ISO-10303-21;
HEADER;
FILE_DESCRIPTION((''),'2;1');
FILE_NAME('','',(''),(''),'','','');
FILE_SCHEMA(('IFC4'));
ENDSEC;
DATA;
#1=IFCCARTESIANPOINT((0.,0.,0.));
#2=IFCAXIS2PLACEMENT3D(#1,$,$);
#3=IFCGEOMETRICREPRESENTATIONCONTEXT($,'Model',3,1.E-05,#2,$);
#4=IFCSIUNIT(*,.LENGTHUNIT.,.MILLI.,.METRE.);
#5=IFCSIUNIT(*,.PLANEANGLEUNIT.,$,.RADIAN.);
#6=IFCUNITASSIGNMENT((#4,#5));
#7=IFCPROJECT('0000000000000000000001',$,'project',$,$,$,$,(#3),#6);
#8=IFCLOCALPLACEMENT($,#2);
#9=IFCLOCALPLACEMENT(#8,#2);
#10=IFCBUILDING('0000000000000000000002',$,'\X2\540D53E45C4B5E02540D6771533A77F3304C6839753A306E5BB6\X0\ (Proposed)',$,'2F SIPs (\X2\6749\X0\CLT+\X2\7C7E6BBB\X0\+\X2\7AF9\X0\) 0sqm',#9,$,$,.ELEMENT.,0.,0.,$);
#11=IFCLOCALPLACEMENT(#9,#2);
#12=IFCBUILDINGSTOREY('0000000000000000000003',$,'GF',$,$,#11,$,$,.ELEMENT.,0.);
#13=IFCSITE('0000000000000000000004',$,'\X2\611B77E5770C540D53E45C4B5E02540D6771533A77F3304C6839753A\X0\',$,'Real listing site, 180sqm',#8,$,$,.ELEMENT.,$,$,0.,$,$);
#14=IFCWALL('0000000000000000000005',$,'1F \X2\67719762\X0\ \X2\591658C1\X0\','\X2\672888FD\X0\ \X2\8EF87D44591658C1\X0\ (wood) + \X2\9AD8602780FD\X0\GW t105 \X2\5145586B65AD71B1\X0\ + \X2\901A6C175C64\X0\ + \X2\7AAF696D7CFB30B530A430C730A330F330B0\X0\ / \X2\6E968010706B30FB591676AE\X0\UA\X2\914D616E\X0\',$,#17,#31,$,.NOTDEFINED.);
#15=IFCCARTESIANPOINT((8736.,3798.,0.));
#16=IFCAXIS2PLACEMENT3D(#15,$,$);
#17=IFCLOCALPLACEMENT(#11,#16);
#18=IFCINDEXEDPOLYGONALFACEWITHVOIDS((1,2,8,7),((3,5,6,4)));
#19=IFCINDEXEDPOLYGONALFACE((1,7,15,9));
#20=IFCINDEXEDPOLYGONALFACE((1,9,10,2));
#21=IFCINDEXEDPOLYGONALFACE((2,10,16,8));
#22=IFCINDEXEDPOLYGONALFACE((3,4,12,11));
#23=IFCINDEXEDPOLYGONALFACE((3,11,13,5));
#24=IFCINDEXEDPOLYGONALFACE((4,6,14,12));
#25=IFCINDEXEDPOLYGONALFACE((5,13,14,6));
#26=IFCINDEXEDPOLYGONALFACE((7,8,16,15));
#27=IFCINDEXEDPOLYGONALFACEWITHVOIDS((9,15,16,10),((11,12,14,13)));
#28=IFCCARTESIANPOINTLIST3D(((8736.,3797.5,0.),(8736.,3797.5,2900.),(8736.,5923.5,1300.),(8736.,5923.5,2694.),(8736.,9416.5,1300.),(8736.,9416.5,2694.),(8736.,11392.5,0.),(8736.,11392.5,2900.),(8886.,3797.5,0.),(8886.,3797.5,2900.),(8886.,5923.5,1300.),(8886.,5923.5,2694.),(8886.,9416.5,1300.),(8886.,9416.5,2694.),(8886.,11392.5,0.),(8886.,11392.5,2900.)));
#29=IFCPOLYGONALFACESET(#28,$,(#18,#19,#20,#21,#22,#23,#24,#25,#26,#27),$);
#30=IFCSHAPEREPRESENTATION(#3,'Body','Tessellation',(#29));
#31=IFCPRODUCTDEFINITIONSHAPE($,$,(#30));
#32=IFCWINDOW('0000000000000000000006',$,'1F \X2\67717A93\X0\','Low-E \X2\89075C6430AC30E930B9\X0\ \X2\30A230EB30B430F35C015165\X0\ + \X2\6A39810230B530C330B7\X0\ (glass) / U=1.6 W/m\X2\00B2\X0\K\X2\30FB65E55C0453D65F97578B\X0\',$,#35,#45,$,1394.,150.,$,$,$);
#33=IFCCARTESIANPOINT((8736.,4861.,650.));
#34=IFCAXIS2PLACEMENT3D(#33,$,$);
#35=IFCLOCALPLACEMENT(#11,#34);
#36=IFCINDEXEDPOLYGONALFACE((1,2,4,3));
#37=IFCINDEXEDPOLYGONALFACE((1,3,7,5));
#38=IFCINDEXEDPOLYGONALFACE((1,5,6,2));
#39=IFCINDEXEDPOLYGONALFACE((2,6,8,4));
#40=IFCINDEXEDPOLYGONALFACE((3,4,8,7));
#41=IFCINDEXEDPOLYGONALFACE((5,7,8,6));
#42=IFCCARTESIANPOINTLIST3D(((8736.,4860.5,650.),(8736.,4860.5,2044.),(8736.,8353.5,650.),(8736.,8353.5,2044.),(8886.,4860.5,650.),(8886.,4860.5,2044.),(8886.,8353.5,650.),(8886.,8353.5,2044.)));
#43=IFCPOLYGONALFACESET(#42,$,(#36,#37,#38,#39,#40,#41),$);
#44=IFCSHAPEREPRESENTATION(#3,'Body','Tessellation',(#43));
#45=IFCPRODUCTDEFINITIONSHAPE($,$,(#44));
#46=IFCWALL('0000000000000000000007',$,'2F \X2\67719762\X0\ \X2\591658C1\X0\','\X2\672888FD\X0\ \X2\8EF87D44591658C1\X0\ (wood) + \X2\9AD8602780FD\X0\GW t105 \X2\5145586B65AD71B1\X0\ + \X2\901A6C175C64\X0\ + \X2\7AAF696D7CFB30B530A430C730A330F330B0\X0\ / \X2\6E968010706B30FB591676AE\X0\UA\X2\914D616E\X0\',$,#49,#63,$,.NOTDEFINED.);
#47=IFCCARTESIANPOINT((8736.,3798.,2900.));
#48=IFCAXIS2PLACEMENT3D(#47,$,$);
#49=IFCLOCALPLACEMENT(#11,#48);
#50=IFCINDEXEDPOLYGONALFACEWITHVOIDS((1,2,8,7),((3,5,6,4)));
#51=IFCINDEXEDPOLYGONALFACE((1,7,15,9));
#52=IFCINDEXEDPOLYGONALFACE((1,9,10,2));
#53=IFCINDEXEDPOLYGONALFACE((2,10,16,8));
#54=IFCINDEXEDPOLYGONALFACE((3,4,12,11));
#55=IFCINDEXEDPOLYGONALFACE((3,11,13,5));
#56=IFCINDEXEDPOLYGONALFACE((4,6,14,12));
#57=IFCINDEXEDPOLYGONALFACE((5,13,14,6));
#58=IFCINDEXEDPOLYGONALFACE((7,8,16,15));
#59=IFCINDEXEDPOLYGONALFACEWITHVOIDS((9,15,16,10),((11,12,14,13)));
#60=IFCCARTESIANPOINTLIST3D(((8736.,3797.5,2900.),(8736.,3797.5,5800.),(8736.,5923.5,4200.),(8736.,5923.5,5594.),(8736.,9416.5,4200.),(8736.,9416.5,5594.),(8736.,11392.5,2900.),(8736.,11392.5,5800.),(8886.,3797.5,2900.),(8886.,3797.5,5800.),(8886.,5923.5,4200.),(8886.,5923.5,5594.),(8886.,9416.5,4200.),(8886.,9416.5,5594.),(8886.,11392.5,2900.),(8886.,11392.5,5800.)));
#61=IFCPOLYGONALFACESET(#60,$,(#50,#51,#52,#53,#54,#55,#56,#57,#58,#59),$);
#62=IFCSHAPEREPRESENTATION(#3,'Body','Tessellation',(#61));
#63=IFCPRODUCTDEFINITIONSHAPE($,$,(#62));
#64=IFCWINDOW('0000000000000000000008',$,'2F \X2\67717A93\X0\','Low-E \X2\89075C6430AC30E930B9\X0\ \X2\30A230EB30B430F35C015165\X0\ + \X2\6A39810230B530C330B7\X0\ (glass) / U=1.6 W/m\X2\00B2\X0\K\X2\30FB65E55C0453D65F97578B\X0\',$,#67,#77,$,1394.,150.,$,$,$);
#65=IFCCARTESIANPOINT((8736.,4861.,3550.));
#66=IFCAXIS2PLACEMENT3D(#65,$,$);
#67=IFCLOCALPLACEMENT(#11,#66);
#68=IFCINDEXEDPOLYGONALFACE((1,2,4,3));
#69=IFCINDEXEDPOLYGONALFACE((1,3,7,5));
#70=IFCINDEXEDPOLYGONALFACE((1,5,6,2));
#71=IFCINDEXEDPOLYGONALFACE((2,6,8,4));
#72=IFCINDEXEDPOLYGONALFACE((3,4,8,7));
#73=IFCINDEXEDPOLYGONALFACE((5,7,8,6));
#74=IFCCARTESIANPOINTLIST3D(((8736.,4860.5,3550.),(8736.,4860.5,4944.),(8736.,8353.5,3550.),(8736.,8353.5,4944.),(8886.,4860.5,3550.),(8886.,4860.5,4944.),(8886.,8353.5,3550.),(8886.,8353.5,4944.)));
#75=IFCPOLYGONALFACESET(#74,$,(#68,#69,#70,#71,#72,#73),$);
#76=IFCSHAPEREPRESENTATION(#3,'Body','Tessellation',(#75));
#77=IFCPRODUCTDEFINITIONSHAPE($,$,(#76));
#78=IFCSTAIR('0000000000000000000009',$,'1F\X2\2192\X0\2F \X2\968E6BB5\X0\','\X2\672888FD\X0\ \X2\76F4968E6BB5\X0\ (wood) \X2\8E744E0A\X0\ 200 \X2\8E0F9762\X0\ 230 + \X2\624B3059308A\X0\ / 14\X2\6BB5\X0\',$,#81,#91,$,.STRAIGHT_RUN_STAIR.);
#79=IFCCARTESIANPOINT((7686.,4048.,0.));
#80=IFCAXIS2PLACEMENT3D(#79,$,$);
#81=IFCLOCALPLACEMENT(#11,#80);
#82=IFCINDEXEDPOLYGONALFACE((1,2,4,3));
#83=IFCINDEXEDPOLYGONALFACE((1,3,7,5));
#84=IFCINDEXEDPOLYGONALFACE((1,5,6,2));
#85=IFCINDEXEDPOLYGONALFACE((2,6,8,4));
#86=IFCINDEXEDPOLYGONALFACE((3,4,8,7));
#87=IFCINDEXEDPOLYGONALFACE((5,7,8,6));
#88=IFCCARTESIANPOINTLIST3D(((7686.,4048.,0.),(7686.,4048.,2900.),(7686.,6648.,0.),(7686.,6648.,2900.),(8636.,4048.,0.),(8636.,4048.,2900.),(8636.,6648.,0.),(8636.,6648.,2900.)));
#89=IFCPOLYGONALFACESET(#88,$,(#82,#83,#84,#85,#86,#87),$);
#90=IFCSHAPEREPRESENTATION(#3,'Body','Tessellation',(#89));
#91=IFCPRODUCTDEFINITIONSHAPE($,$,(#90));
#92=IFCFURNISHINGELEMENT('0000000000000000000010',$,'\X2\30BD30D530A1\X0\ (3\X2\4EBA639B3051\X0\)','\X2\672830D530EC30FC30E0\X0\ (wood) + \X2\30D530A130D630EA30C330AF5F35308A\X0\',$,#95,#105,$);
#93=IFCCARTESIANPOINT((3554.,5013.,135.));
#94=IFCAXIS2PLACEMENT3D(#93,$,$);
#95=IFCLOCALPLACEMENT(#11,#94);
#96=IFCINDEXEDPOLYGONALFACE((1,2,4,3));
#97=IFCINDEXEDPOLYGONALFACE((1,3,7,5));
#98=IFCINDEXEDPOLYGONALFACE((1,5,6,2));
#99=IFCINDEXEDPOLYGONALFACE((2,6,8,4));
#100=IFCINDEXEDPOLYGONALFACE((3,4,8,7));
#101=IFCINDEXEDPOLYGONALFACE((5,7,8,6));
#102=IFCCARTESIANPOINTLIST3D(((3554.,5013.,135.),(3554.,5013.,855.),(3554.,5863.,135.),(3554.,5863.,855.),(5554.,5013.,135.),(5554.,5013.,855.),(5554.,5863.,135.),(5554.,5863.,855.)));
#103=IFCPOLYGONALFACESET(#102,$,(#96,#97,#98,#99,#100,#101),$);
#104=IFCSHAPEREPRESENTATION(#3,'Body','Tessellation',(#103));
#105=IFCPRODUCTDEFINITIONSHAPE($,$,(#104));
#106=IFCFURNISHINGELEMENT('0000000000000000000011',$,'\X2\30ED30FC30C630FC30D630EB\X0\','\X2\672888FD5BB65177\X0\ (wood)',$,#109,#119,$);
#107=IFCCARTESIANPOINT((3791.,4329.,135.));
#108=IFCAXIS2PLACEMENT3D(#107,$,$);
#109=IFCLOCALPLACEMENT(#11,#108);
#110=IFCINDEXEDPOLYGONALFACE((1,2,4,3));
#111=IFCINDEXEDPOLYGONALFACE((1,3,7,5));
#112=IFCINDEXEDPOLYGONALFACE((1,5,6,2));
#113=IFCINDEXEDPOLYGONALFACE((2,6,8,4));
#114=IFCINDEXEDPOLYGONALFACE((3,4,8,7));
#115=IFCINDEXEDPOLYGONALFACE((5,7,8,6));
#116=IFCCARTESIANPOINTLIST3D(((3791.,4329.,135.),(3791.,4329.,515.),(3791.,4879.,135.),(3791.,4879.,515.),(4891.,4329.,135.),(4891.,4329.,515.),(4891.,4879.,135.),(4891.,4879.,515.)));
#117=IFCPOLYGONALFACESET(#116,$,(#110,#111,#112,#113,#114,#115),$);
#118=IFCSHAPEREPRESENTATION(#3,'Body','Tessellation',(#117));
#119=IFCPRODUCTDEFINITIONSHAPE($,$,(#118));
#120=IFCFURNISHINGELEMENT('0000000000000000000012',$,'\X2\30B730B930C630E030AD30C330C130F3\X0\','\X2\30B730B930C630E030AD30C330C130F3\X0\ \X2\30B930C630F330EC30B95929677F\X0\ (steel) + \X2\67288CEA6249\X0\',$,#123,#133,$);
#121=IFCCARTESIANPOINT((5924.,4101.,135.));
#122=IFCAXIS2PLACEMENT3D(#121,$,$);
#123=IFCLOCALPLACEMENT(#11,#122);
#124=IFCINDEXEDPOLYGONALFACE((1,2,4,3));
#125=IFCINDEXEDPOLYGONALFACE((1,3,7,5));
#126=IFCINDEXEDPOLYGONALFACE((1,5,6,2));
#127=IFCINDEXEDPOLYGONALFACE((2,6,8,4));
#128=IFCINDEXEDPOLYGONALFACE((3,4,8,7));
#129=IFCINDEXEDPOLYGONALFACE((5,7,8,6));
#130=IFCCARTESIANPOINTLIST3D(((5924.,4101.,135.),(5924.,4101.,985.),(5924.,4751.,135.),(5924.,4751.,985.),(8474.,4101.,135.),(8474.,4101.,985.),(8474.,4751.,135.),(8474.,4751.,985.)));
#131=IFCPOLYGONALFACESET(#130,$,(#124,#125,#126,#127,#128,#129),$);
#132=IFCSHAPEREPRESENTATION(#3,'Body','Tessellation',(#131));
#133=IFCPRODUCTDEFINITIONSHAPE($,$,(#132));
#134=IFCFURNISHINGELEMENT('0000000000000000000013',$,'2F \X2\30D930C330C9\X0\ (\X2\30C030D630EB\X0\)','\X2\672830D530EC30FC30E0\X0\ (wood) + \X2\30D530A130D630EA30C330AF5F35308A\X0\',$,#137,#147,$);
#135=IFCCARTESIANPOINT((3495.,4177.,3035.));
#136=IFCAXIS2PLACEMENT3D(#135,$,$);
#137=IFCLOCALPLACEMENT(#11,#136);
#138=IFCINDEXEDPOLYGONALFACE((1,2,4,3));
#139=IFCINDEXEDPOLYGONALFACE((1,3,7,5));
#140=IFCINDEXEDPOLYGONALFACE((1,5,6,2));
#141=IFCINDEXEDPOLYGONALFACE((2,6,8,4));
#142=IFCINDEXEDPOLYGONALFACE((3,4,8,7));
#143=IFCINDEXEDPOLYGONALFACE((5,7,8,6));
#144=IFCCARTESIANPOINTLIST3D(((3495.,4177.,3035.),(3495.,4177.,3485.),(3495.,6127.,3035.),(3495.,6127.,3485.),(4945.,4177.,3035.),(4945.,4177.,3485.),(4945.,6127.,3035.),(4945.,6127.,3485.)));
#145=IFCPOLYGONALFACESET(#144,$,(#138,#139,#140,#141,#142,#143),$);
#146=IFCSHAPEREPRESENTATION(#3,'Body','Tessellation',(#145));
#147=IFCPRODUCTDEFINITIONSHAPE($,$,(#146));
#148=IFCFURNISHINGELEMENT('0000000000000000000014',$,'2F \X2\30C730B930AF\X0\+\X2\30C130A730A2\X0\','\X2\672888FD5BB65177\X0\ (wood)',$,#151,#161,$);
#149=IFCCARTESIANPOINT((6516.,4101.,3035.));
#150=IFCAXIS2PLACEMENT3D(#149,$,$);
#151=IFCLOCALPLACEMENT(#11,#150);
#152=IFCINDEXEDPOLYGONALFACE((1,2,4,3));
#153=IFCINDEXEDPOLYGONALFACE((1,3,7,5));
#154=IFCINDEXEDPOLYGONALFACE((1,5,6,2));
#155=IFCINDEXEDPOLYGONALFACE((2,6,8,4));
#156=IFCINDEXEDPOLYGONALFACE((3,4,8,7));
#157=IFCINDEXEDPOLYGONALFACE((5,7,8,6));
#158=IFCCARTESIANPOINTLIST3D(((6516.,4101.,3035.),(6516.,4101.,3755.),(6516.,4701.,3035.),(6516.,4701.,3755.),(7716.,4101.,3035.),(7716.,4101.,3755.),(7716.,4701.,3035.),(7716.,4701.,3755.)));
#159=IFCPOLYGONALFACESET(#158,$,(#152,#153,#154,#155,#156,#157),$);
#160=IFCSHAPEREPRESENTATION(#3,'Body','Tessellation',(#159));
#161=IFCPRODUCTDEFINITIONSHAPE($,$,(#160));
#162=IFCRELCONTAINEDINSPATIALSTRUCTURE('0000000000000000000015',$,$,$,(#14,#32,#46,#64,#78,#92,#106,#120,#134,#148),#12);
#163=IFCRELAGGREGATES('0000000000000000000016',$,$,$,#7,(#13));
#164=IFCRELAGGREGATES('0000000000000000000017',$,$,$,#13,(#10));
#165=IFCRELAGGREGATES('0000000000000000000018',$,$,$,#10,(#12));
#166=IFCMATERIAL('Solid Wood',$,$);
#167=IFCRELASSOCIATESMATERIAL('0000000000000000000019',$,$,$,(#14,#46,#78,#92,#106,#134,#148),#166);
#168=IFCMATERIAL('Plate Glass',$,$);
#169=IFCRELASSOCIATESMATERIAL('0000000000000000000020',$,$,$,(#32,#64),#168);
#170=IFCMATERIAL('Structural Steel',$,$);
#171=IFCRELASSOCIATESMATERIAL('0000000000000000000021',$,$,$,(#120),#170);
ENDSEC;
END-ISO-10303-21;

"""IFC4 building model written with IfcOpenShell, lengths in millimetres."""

from ifc_helpers import new_model, si_unit, frame, frame_2d, origin, place, context, project, spatial, rectangle, extrude, material, element, fill, save


model = new_model("IFC4")

# Units and contexts
model_context = context("Model", 3, precision=1e-05, world=origin())
ifc_project = project(units=[si_unit("LENGTHUNIT", "METRE", prefix="MILLI"), si_unit("PLANEANGLEUNIT", "RADIAN")], contexts=[model_context])

# Site, building, storey
site_placement = place(None, origin())
site = spatial("IfcSite", under=ifc_project, at=site_placement, Name="愛知県名古屋市名東区石が根町", ObjectType="Real listing site, 180sqm", CompositionType="ELEMENT", RefElevation=0.0)
building_placement = place(site_placement, origin())
building = spatial("IfcBuilding", under=site, at=building_placement, Name="名古屋市名東区石が根町の家 (Proposed)", ObjectType="2F SIPs (杉CLT+籾殻+竹) 0sqm", CompositionType="ELEMENT", ElevationOfRefHeight=0.0, ElevationOfTerrain=0.0)
storey_placement = place(building_placement, origin())
storey = spatial("IfcBuildingStorey", under=building, at=storey_placement, Name="GF", CompositionType="ELEMENT", Elevation=0.0)

# Wall, opening, window
ifc_material_1 = material(Name="Solid Wood")
wall_1_placement = place(storey_placement, frame((8736.0, 3798.0, 0.0)))
wall_1 = element("IfcWall", 1, at=wall_1_placement, inside=storey, material=ifc_material_1, Name="1F 東面 外壁", Description="木製 軸組外壁 (wood) + 高性能GW t105 充填断熱 + 通気層 + 窯業系サイディング / 準耐火・外皮UA配慮", PredefinedType="NOTDEFINED", context=model_context, shape_type="SweptSolid", body=[
    extrude(rectangle(XDim=150.0, YDim=7595.0, at=frame_2d((75.0, 3797.0))), frame((8736.0, 3798.0, 0.0)), (0.0, 0.0, 1.0), 2900.0),
])
opening_1_placement = place(storey_placement, frame((8736.0, 4861.0, 650.0)))
opening_1 = element("IfcOpeningElement", 2, at=opening_1_placement, cuts=wall_1, PredefinedType="NOTDEFINED", context=model_context, shape_type="SweptSolid", body=[
    extrude(rectangle(XDim=150.0, YDim=3493.0, at=frame_2d((75.0, 1746.0))), frame((8736.0, 4861.0, 650.0)), (0.0, 0.0, 1.0), 1394.0),
])
ifc_material_2 = material(Name="Plate Glass")
window_1_placement = place(storey_placement, frame((8736.0, 4861.0, 650.0)))
window_1 = element("IfcWindow", 3, at=window_1_placement, inside=storey, material=ifc_material_2, Name="1F 東窓", Description="Low-E 複層ガラス アルゴン封入 + 樹脂サッシ (glass) / U=1.6 W/m²K・日射取得型", OverallHeight=1394.0, OverallWidth=150.0, context=model_context, shape_type="SweptSolid", body=[
    extrude(rectangle(XDim=150.0, YDim=3493.0, at=frame_2d((75.0, 1746.0))), frame((8736.0, 4861.0, 650.0)), (0.0, 0.0, 1.0), 1394.0),
])
fill(opening_1, window_1)

# Wall, opening, window
wall_2_placement = place(storey_placement, frame((8736.0, 3798.0, 2900.0)))
wall_2 = element("IfcWall", 4, at=wall_2_placement, inside=storey, material=ifc_material_1, Name="2F 東面 外壁", Description="木製 軸組外壁 (wood) + 高性能GW t105 充填断熱 + 通気層 + 窯業系サイディング / 準耐火・外皮UA配慮", PredefinedType="NOTDEFINED", context=model_context, shape_type="SweptSolid", body=[
    extrude(rectangle(XDim=150.0, YDim=7595.0, at=frame_2d((75.0, 3797.0))), frame((8736.0, 3798.0, 2900.0)), (0.0, 0.0, 1.0), 2900.0),
])
opening_2_placement = place(storey_placement, frame((8736.0, 4861.0, 3550.0)))
opening_2 = element("IfcOpeningElement", 5, at=opening_2_placement, cuts=wall_2, PredefinedType="NOTDEFINED", context=model_context, shape_type="SweptSolid", body=[
    extrude(rectangle(XDim=150.0, YDim=3493.0, at=frame_2d((75.0, 1746.0))), frame((8736.0, 4861.0, 3550.0)), (0.0, 0.0, 1.0), 1394.0),
])
window_2_placement = place(storey_placement, frame((8736.0, 4861.0, 3550.0)))
window_2 = element("IfcWindow", 6, at=window_2_placement, inside=storey, material=ifc_material_2, Name="2F 東窓", Description="Low-E 複層ガラス アルゴン封入 + 樹脂サッシ (glass) / U=1.6 W/m²K・日射取得型", OverallHeight=1394.0, OverallWidth=150.0, context=model_context, shape_type="SweptSolid", body=[
    extrude(rectangle(XDim=150.0, YDim=3493.0, at=frame_2d((75.0, 1746.0))), frame((8736.0, 4861.0, 3550.0)), (0.0, 0.0, 1.0), 1394.0),
])
fill(opening_2, window_2)

# Stair
stair_placement = place(storey_placement, frame((7686.0, 4048.0, 0.0)))
element("IfcStair", 7, at=stair_placement, inside=storey, material=ifc_material_1, Name="1F→2F 階段", Description="木製 直階段 (wood) 蹴上 200 踏面 230 + 手すり / 14段", PredefinedType="STRAIGHT_RUN_STAIR", context=model_context, shape_type="SweptSolid", body=[
    extrude(rectangle(XDim=950.0, YDim=2600.0, at=frame_2d((475.0, 1300.0))), frame((7686.0, 4048.0, 0.0)), (0.0, 0.0, 1.0), 2900.0),
])

# Furnishing elements
furnishing_1_placement = place(storey_placement, frame((3554.0, 5013.0, 135.0)))
element("IfcFurnishingElement", 8, at=furnishing_1_placement, inside=storey, material=ifc_material_1, Name="ソファ (3人掛け)", Description="木フレーム (wood) + ファブリック張り", context=model_context, shape_type="SweptSolid", body=[
    extrude(rectangle(XDim=2000.0, YDim=850.0, at=frame_2d((1000.0, 425.0))), frame((3554.0, 5013.0, 135.0)), (0.0, 0.0, 1.0), 720.0),
])
furnishing_2_placement = place(storey_placement, frame((3791.0, 4329.0, 135.0)))
element("IfcFurnishingElement", 9, at=furnishing_2_placement, inside=storey, material=ifc_material_1, Name="ローテーブル", Description="木製家具 (wood)", context=model_context, shape_type="SweptSolid", body=[
    extrude(rectangle(XDim=1100.0, YDim=550.0, at=frame_2d((550.0, 275.0))), frame((3791.0, 4329.0, 135.0)), (0.0, 0.0, 1.0), 380.0),
])
ifc_material_3 = material(Name="Structural Steel")
furnishing_3_placement = place(storey_placement, frame((5924.0, 4101.0, 135.0)))
element("IfcFurnishingElement", 10, at=furnishing_3_placement, inside=storey, material=ifc_material_3, Name="システムキッチン", Description="システムキッチン ステンレス天板 (steel) + 木質扉", context=model_context, shape_type="SweptSolid", body=[
    extrude(rectangle(XDim=2550.0, YDim=650.0, at=frame_2d((1275.0, 325.0))), frame((5924.0, 4101.0, 135.0)), (0.0, 0.0, 1.0), 850.0),
])
furnishing_4_placement = place(storey_placement, frame((3495.0, 4177.0, 3035.0)))
element("IfcFurnishingElement", 11, at=furnishing_4_placement, inside=storey, material=ifc_material_1, Name="2F ベッド (ダブル)", Description="木フレーム (wood) + ファブリック張り", context=model_context, shape_type="SweptSolid", body=[
    extrude(rectangle(XDim=1450.0, YDim=1950.0, at=frame_2d((725.0, 975.0))), frame((3495.0, 4177.0, 3035.0)), (0.0, 0.0, 1.0), 450.0),
])
furnishing_5_placement = place(storey_placement, frame((6516.0, 4101.0, 3035.0)))
element("IfcFurnishingElement", 12, at=furnishing_5_placement, inside=storey, material=ifc_material_1, Name="2F デスク+チェア", Description="木製家具 (wood)", context=model_context, shape_type="SweptSolid", body=[
    extrude(rectangle(XDim=1200.0, YDim=600.0, at=frame_2d((600.0, 300.0))), frame((6516.0, 4101.0, 3035.0)), (0.0, 0.0, 1.0), 720.0),
])

save(model, "model.ifc")
